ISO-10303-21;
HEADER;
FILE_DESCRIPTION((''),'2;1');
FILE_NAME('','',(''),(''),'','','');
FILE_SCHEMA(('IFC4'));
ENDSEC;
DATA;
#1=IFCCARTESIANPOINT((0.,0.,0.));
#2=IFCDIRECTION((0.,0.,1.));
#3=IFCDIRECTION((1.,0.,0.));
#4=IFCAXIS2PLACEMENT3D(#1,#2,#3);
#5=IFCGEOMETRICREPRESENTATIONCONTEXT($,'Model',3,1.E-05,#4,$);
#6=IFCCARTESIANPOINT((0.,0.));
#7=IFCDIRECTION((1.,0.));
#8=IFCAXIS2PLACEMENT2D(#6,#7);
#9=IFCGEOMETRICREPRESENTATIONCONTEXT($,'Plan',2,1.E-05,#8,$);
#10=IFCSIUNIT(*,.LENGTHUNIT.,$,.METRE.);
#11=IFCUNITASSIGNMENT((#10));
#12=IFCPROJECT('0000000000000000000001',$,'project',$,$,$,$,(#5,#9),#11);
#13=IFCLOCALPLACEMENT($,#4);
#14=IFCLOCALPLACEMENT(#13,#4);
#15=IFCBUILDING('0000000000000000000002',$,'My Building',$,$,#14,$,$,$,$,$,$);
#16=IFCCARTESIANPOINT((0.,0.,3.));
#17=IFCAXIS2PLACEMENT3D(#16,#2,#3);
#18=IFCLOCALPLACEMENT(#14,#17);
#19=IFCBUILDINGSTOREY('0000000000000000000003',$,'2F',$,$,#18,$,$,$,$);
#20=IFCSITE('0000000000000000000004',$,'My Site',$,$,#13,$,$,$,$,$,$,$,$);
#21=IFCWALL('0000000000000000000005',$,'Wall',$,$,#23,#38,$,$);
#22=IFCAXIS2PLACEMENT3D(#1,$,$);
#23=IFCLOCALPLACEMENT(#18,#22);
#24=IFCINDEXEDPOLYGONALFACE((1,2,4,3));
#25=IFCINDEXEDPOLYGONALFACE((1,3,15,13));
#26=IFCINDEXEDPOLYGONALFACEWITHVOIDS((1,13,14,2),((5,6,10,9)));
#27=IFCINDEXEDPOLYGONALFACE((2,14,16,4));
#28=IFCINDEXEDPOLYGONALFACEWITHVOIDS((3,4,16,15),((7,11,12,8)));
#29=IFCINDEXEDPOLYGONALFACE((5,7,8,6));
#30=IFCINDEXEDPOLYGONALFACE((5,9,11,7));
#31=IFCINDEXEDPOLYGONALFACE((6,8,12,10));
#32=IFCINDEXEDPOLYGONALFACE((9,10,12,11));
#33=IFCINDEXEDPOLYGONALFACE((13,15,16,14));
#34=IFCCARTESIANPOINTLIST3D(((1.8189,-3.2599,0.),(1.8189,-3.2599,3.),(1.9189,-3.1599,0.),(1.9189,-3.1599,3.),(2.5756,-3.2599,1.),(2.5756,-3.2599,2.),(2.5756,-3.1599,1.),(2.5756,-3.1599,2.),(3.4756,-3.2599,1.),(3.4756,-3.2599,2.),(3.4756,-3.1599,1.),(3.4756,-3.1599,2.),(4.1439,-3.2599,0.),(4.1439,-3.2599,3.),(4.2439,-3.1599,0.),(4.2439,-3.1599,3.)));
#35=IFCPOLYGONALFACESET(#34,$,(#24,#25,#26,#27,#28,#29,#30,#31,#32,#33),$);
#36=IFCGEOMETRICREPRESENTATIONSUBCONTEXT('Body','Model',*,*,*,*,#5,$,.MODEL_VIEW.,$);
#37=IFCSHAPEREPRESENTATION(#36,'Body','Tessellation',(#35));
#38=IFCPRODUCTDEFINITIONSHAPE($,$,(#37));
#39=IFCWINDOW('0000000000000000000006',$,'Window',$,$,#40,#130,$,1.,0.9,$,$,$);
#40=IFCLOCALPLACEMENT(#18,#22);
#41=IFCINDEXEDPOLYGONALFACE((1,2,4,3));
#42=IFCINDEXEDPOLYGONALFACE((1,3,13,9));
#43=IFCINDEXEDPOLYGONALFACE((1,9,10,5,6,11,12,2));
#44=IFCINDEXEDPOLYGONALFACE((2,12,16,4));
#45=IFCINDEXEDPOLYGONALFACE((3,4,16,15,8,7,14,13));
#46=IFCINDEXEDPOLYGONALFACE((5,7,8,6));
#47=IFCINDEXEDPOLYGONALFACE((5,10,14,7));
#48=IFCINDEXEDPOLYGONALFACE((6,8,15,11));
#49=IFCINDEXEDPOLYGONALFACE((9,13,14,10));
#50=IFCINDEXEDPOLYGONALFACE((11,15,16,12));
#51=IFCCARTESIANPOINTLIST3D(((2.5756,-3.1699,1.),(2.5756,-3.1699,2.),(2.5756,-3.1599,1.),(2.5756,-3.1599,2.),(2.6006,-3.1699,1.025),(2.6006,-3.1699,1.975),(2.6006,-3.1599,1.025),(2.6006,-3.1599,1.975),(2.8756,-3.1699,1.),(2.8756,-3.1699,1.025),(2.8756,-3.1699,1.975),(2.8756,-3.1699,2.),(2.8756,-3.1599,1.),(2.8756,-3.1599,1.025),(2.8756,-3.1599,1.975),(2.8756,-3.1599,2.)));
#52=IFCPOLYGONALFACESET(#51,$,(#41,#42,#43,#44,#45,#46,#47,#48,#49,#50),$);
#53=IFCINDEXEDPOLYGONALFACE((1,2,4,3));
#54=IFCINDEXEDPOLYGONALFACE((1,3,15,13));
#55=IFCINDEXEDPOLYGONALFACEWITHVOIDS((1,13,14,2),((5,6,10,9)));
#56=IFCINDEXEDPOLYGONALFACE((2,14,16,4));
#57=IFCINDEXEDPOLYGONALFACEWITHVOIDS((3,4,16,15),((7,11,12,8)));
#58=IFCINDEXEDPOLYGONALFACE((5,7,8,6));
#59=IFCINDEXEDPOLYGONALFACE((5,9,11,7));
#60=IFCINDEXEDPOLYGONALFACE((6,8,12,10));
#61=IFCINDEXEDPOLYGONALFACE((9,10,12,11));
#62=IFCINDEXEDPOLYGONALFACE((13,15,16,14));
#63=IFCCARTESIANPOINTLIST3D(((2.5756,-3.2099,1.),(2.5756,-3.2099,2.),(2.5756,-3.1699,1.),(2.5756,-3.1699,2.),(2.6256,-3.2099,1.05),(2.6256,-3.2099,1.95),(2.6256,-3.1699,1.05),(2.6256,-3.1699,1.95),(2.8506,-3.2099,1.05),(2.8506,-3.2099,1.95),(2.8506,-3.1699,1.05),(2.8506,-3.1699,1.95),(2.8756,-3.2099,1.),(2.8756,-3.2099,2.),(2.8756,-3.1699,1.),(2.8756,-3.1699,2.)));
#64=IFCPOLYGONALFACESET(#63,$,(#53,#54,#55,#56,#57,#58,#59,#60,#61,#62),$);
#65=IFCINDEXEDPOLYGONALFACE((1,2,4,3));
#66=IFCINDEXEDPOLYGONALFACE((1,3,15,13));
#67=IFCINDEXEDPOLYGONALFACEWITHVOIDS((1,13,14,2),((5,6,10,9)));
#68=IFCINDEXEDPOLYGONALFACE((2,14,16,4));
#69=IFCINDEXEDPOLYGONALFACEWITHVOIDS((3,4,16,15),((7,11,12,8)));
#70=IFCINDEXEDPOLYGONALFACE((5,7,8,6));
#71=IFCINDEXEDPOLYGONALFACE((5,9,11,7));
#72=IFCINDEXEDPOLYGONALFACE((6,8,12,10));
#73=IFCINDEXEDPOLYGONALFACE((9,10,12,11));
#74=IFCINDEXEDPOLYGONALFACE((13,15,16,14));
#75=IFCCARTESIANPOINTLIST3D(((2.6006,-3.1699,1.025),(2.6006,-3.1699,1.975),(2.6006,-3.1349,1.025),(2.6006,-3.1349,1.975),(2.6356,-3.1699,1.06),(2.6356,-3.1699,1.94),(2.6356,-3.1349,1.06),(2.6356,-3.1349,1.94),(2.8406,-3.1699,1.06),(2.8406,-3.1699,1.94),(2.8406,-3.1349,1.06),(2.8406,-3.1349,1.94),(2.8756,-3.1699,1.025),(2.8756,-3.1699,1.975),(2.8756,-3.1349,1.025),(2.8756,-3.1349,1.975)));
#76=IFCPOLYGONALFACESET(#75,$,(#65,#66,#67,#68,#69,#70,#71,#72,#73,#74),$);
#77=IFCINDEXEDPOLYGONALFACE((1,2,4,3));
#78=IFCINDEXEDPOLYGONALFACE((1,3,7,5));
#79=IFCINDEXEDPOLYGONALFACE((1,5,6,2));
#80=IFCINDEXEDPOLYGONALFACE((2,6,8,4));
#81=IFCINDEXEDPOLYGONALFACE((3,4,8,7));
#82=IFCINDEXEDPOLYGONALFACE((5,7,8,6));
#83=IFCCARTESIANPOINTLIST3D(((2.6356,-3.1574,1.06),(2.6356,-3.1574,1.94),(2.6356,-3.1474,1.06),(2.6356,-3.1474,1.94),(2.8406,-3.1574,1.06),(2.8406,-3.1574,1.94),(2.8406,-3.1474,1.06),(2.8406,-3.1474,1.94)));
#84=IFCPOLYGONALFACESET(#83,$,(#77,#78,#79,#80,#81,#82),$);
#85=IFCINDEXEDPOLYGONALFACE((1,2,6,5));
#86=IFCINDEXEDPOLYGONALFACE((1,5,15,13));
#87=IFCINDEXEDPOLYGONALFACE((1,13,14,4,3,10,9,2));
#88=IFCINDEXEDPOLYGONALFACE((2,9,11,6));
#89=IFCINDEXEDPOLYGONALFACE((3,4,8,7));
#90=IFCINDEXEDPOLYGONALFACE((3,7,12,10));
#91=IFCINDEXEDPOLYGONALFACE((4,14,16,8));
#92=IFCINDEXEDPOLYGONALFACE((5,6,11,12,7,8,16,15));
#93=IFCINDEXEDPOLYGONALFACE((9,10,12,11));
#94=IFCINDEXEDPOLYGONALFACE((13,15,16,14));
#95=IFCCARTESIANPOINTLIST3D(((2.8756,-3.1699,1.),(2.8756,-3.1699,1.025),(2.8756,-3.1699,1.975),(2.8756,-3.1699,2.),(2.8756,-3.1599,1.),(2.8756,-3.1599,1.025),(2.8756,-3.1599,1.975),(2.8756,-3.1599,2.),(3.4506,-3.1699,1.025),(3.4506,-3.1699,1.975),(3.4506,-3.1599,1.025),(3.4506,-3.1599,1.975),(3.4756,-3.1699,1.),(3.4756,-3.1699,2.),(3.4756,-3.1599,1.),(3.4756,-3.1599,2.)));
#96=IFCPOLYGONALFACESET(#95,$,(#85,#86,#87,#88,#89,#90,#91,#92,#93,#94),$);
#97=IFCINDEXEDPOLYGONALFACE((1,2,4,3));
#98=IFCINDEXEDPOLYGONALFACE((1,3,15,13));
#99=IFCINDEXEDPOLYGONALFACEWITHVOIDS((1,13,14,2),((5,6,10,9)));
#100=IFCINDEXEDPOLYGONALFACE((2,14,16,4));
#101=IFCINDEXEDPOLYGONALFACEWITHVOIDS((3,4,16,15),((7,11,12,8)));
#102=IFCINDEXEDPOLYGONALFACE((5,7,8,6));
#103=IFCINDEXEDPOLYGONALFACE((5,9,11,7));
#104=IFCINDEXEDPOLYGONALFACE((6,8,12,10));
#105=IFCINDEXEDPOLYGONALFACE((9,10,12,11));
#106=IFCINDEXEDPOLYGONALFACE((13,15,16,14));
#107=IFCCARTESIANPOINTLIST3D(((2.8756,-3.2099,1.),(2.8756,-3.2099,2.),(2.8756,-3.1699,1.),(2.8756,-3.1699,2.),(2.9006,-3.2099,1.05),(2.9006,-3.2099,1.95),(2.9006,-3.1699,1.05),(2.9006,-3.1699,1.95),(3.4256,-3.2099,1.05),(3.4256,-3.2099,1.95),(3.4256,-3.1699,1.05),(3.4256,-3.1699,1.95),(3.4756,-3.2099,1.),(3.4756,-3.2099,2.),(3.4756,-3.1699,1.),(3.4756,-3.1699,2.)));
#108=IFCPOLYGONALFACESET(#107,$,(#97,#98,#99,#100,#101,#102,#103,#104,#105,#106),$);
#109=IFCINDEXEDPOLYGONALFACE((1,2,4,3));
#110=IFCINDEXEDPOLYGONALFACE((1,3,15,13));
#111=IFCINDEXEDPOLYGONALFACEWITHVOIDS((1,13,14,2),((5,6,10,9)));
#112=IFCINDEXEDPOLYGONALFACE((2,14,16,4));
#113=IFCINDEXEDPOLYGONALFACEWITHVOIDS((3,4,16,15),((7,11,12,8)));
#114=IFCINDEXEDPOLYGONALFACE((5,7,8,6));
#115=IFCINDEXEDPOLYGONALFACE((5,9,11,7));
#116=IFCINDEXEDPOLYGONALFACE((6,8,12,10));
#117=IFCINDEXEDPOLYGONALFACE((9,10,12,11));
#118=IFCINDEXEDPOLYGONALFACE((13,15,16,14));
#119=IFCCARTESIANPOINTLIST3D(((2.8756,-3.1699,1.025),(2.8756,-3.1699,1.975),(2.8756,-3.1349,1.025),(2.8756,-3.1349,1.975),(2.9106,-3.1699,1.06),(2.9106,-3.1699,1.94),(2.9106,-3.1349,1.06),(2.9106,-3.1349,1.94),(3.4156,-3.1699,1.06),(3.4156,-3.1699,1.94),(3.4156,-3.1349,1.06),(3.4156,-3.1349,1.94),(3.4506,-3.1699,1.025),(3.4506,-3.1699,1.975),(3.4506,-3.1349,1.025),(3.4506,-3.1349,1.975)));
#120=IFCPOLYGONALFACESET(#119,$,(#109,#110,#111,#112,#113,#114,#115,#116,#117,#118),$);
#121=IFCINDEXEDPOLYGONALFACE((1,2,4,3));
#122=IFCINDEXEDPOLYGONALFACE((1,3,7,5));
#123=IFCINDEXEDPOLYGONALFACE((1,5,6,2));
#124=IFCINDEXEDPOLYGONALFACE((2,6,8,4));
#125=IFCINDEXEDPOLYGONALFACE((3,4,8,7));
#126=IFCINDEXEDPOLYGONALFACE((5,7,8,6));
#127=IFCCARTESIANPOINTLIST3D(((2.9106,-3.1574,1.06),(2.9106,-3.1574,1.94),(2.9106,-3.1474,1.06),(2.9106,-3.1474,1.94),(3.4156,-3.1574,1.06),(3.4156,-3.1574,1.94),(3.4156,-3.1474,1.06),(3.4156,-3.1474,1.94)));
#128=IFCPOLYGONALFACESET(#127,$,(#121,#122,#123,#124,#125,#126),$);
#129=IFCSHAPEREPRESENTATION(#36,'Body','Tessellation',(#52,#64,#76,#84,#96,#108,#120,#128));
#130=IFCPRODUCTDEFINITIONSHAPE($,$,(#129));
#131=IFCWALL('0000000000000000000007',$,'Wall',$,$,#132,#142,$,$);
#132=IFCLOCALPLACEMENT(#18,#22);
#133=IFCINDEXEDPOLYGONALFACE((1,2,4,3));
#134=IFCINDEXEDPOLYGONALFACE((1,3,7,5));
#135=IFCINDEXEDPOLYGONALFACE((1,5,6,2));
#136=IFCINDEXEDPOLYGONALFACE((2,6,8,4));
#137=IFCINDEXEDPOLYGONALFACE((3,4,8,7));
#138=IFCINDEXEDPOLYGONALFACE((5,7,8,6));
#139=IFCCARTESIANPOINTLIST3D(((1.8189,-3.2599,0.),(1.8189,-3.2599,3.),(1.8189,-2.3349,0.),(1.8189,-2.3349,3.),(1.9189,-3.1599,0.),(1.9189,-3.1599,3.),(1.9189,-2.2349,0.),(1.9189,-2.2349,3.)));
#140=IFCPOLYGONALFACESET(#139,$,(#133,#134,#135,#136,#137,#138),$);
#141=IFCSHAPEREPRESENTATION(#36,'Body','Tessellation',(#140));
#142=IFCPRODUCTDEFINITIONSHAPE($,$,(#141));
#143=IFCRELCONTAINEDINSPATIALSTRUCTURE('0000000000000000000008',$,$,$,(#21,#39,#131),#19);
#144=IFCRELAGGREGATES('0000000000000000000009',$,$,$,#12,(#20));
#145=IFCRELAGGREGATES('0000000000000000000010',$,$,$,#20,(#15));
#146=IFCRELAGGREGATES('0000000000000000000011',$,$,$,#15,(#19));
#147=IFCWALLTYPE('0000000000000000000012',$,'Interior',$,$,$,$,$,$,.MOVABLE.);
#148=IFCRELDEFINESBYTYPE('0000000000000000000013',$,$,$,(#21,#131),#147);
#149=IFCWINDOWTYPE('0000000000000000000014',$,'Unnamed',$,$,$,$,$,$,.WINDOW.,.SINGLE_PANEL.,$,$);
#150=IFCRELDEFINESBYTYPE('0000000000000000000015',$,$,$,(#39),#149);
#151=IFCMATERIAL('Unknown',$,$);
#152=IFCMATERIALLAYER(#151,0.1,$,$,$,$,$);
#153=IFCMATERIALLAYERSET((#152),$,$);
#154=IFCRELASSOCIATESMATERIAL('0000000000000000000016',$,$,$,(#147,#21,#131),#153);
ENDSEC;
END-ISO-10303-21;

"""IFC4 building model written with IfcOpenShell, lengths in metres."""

from ifc_helpers import new_model, entity, si_unit, frame, origin_with_axes, origin_2d_with_axis, place, context, subcontext, project, spatial, line, indexed_curve, outline, extrude, shape, source, transform, mapped, material, layer, layer_set, layer_usage, type_object, type_shapes, element, fill, save


model = new_model("IFC4")

# Units and contexts
model_context = context("Model", 3, precision=1e-05, world=origin_with_axes())
plan_context = context("Plan", 2, precision=1e-05, world=origin_2d_with_axis())
body_context_1 = subcontext(model_context, "Body", "Model", "MODEL_VIEW")
body_context_2 = subcontext(plan_context, "Body", "Plan", "PLAN_VIEW")
ifc_project = project(units=[si_unit("LENGTHUNIT", "METRE")], contexts=[model_context, plan_context])

# Site, building, storey
site_placement = place(None, origin_with_axes())
site = spatial("IfcSite", under=ifc_project, at=site_placement, Name="My Site")
building_placement = place(site_placement, origin_with_axes())
building = spatial("IfcBuilding", under=site, at=building_placement, Name="My Building")
storey_placement = place(building_placement, frame((0.0, 0.0, 3.0), z_axis=(0.0, 0.0, 1.0), x_axis=(1.0, 0.0, 0.0)))
storey = spatial("IfcBuildingStorey", under=building, at=storey_placement, Name="2F")

# Shared definitions
ifc_material = material(Name="Unknown")

# Shared definitions
ifc_layer_1 = layer(ifc_material, 0.1)
ifc_layer_set_1 = layer_set([ifc_layer_1])
wall_type = type_object("IfcWallType", Name="Interior", PredefinedType="MOVABLE", material=ifc_layer_set_1)

# Shared definitions
shared_shape_1 = source(origin_with_axes(), body_context_1, "Body", "SweptSolid", [
    extrude(outline(indexed_curve([(0.0, 0.0), (0.9, 0.0), (0.9, 1.0), (0.0, 1.0)], segments=[line(1, 2, 3, 4, 1)])), frame((0.0, -0.6, 0.0), z_axis=(0.0, -1.0, 0.0), x_axis=(1.0, 0.0, 0.0)), (0.0, 0.0, -1.0), 1.2),
])
window_type = type_object("IfcWindowType", Name="Unnamed", PartitioningType="SINGLE_PANEL", PredefinedType="WINDOW")
shared_shape_2 = source(origin_with_axes(), body_context_1, "Body", "SweptSolid", [
    extrude(outline(indexed_curve([(0.3, 0.0), (0.0, 0.0), (0.0, 1.0), (0.3, 1.0), (0.3, 0.975), (0.025, 0.975), (0.025, 0.025), (0.3, 0.025)], segments=[line(1, 2, 3, 4, 5, 6, 7, 8, 1)])), frame((0.0, 0.09, 0.0), z_axis=(0.0, -1.0, 0.0), x_axis=(1.0, 0.0, 0.0)), (0.0, 0.0, -1.0), 0.01),
    extrude(outline(indexed_curve([(0.0, 0.0), (0.3, 0.0), (0.3, 1.0), (0.0, 1.0)], segments=[line(1, 2, 3, 4, 1)]), holes=[indexed_curve([(0.05, 0.05), (0.275, 0.05), (0.275, 0.95), (0.05, 0.95)], segments=[line(1, 2, 3, 4, 1)])]), frame((0.0, 0.05, 0.0), z_axis=(0.0, -1.0, 0.0), x_axis=(1.0, 0.0, 0.0)), (0.0, 0.0, -1.0), 0.04),
    extrude(outline(indexed_curve([(0.0, 0.0), (0.275, 0.0), (0.275, 0.95), (0.0, 0.95)], segments=[line(1, 2, 3, 4, 1)]), holes=[indexed_curve([(0.035, 0.035), (0.24, 0.035), (0.24, 0.915), (0.035, 0.915)], segments=[line(1, 2, 3, 4, 1)])]), frame((0.025, 0.09, 0.025), z_axis=(0.0, -1.0, 0.0), x_axis=(1.0, 0.0, 0.0)), (0.0, 0.0, -1.0), 0.035),
    extrude(outline(indexed_curve([(0.035, 0.035), (0.24, 0.035), (0.24, 0.915), (0.035, 0.915)], segments=[line(1, 2, 3, 4, 1)])), frame((0.025, 0.1025, 0.025), z_axis=(0.0, -1.0, 0.0), x_axis=(1.0, 0.0, 0.0)), (0.0, 0.0, -1.0), 0.01),
    extrude(outline(indexed_curve([(0.0, 1.0), (0.6, 1.0), (0.6, 0.0), (0.0, 0.0), (0.0, 0.025), (0.575, 0.025), (0.575, 0.975), (0.0, 0.975)], segments=[line(1, 2, 3, 4, 5, 6, 7, 8, 1)])), frame((0.3, 0.09, 0.0), z_axis=(0.0, -1.0, 0.0), x_axis=(1.0, 0.0, 0.0)), (0.0, 0.0, -1.0), 0.01),
    extrude(outline(indexed_curve([(0.0, 0.0), (0.6, 0.0), (0.6, 1.0), (0.0, 1.0)], segments=[line(1, 2, 3, 4, 1)]), holes=[indexed_curve([(0.025, 0.05), (0.55, 0.05), (0.55, 0.95), (0.025, 0.95)], segments=[line(1, 2, 3, 4, 1)])]), frame((0.3, 0.05, 0.0), z_axis=(0.0, -1.0, 0.0), x_axis=(1.0, 0.0, 0.0)), (0.0, 0.0, -1.0), 0.04),
    extrude(outline(indexed_curve([(0.0, 0.0), (0.575, 0.0), (0.575, 0.95), (0.0, 0.95)], segments=[line(1, 2, 3, 4, 1)]), holes=[indexed_curve([(0.035, 0.035), (0.54, 0.035), (0.54, 0.915), (0.035, 0.915)], segments=[line(1, 2, 3, 4, 1)])]), frame((0.3, 0.09, 0.025), z_axis=(0.0, -1.0, 0.0), x_axis=(1.0, 0.0, 0.0)), (0.0, 0.0, -1.0), 0.035),
    extrude(outline(indexed_curve([(0.035, 0.035), (0.54, 0.035), (0.54, 0.915), (0.035, 0.915)], segments=[line(1, 2, 3, 4, 1)])), frame((0.3, 0.1025, 0.025), z_axis=(0.0, -1.0, 0.0), x_axis=(1.0, 0.0, 0.0)), (0.0, 0.0, -1.0), 0.01),
])
shared_shape_3 = source(origin_with_axes(), body_context_2, "Body", "Curve2D", [
    entity("IfcIndexedPolyCurve", entity("IfcCartesianPointList2D", [[0.05, 0.05], [0.275, 0.05]])),
    entity("IfcIndexedPolyCurve", entity("IfcCartesianPointList2D", [[0.0, 0.1], [0.025, 0.1], [0.025, 0.09], [0.05, 0.09], [0.05, 0.05], [0.0, 0.05]]), [entity("IfcLineIndex", [1, 2, 3, 4, 5, 6, 1])]),
    entity("IfcIndexedPolyCurve", entity("IfcCartesianPointList2D", [[0.3, 0.1], [0.3, 0.1], [0.3, 0.09], [0.275, 0.09], [0.275, 0.05], [0.3, 0.05]])),
    entity("IfcIndexedPolyCurve", entity("IfcCartesianPointList2D", [[0.025, 0.09], [0.06, 0.09], [0.06, 0.125], [0.025, 0.125]]), [entity("IfcLineIndex", [1, 2, 3, 4, 1])]),
    entity("IfcIndexedPolyCurve", entity("IfcCartesianPointList2D", [[0.3, 0.09], [0.265, 0.09], [0.265, 0.125], [0.3, 0.125]]), [entity("IfcLineIndex", [1, 2, 3, 4, 1])]),
    entity("IfcIndexedPolyCurve", entity("IfcCartesianPointList2D", [[0.06, 0.09], [0.265, 0.09]])),
    entity("IfcIndexedPolyCurve", entity("IfcCartesianPointList2D", [[0.06, 0.125], [0.265, 0.125]])),
    entity("IfcIndexedPolyCurve", entity("IfcCartesianPointList2D", [[0.06, 0.1075], [0.265, 0.1075]])),
    entity("IfcIndexedPolyCurve", entity("IfcCartesianPointList2D", [[0.325, 0.05], [0.85, 0.05]])),
    entity("IfcIndexedPolyCurve", entity("IfcCartesianPointList2D", [[0.3, 0.1], [0.3, 0.1], [0.3, 0.09], [0.325, 0.09], [0.325, 0.05], [0.3, 0.05]])),
    entity("IfcIndexedPolyCurve", entity("IfcCartesianPointList2D", [[0.9, 0.1], [0.875, 0.1], [0.875, 0.09], [0.85, 0.09], [0.85, 0.05], [0.9, 0.05]]), [entity("IfcLineIndex", [1, 2, 3, 4, 5, 6, 1])]),
    entity("IfcIndexedPolyCurve", entity("IfcCartesianPointList2D", [[0.3, 0.09], [0.335, 0.09], [0.335, 0.125], [0.3, 0.125]]), [entity("IfcLineIndex", [1, 2, 3, 4, 1])]),
    entity("IfcIndexedPolyCurve", entity("IfcCartesianPointList2D", [[0.875, 0.09], [0.84, 0.09], [0.84, 0.125], [0.875, 0.125]]), [entity("IfcLineIndex", [1, 2, 3, 4, 1])]),
    entity("IfcIndexedPolyCurve", entity("IfcCartesianPointList2D", [[0.335, 0.09], [0.84, 0.09]])),
    entity("IfcIndexedPolyCurve", entity("IfcCartesianPointList2D", [[0.335, 0.125], [0.84, 0.125]])),
    entity("IfcIndexedPolyCurve", entity("IfcCartesianPointList2D", [[0.335, 0.1075], [0.84, 0.1075]])),
])
type_shapes(window_type, [shared_shape_2, shared_shape_3])

# Wall, opening, window
ifc_layer_usage_1 = layer_usage(ifc_layer_set_1, "AXIS2", "POSITIVE", 0.0)
wall_1_placement = place(storey_placement, frame((4.1439, -3.1599, 0.0), z_axis=(0.0, 0.0, 1.0), x_axis=(-1.0, 0.0, 0.0)))
wall_1 = element("IfcWall", 1, at=wall_1_placement, inside=storey, type_object=wall_type, material=ifc_layer_usage_1, Name="Wall", context=body_context_1, shape_type="SweptSolid", body=[
    extrude(outline(indexed_curve([(-0.1, 0.0), (0.0, 0.1), (2.325, 0.1), (2.225, 0.0)], segments=[line(1, 2, 3, 4, 1)])), origin_with_axes(), (0.0, 0.0, 1.0), 3.0),
])
opening_1_placement = place(wall_1_placement, frame((1.5683, 0.1, 1.0), z_axis=(0.0, 0.0, 1.0), x_axis=(-1.0, 0.0, 0.0)))
opening_1 = element("IfcOpeningElement", 2, at=opening_1_placement, cuts=wall_1, PredefinedType="OPENING", context=body_context_1, shape_type="MappedRepresentation", body=[
    mapped(shared_shape_1, transform((0.0, 0.0, 0.0), x_axis=(1.0, 0.0, 0.0), y_axis=(0.0, 1.0, 0.0), z_axis=(0.0, 0.0, 1.0), scale=1.0)),
])
window_1_placement = place(opening_1_placement, frame((0.0, 0.0, 0.0), z_axis=(0.0, 0.0, 1.0), x_axis=(1.0, 0.0, 0.0)))
window_1 = element("IfcWindow", 3, at=window_1_placement, inside=storey, type_object=window_type, Name="Window", OverallHeight=1.0, OverallWidth=0.9, shapes=[
    shape(body_context_1, "Body", "MappedRepresentation", [mapped(shared_shape_2, transform((0.0, 0.0, 0.0), x_axis=(1.0, 0.0, 0.0), y_axis=(0.0, 1.0, 0.0), z_axis=(0.0, 0.0, 1.0), scale=1.0))]),
    shape(body_context_2, "Body", "MappedRepresentation", [mapped(shared_shape_3, transform((0.0, 0.0, 0.0), x_axis=(1.0, 0.0, 0.0), y_axis=(0.0, 1.0, 0.0), z_axis=(0.0, 0.0, 1.0), scale=1.0))]),
])
fill(opening_1, window_1)

# Wall
ifc_layer_usage_2 = layer_usage(ifc_layer_set_1, "AXIS2", "POSITIVE", 0.0)
wall_2_placement = place(storey_placement, frame((1.9189, -3.1599, 0.0), z_axis=(0.0, 0.0, 1.0), x_axis=(0.0, 1.0, 0.0)))
element("IfcWall", 4, at=wall_2_placement, inside=storey, type_object=wall_type, material=ifc_layer_usage_2, Name="Wall", context=body_context_1, shape_type="SweptSolid", body=[
    extrude(outline(indexed_curve([(0.0, 0.0), (-0.1, 0.1), (0.825, 0.1), (0.925, 0.0)], segments=[line(1, 2, 3, 4, 1)])), origin_with_axes(), (0.0, 0.0, 1.0), 3.0),
])

save(model, "model.ifc")
